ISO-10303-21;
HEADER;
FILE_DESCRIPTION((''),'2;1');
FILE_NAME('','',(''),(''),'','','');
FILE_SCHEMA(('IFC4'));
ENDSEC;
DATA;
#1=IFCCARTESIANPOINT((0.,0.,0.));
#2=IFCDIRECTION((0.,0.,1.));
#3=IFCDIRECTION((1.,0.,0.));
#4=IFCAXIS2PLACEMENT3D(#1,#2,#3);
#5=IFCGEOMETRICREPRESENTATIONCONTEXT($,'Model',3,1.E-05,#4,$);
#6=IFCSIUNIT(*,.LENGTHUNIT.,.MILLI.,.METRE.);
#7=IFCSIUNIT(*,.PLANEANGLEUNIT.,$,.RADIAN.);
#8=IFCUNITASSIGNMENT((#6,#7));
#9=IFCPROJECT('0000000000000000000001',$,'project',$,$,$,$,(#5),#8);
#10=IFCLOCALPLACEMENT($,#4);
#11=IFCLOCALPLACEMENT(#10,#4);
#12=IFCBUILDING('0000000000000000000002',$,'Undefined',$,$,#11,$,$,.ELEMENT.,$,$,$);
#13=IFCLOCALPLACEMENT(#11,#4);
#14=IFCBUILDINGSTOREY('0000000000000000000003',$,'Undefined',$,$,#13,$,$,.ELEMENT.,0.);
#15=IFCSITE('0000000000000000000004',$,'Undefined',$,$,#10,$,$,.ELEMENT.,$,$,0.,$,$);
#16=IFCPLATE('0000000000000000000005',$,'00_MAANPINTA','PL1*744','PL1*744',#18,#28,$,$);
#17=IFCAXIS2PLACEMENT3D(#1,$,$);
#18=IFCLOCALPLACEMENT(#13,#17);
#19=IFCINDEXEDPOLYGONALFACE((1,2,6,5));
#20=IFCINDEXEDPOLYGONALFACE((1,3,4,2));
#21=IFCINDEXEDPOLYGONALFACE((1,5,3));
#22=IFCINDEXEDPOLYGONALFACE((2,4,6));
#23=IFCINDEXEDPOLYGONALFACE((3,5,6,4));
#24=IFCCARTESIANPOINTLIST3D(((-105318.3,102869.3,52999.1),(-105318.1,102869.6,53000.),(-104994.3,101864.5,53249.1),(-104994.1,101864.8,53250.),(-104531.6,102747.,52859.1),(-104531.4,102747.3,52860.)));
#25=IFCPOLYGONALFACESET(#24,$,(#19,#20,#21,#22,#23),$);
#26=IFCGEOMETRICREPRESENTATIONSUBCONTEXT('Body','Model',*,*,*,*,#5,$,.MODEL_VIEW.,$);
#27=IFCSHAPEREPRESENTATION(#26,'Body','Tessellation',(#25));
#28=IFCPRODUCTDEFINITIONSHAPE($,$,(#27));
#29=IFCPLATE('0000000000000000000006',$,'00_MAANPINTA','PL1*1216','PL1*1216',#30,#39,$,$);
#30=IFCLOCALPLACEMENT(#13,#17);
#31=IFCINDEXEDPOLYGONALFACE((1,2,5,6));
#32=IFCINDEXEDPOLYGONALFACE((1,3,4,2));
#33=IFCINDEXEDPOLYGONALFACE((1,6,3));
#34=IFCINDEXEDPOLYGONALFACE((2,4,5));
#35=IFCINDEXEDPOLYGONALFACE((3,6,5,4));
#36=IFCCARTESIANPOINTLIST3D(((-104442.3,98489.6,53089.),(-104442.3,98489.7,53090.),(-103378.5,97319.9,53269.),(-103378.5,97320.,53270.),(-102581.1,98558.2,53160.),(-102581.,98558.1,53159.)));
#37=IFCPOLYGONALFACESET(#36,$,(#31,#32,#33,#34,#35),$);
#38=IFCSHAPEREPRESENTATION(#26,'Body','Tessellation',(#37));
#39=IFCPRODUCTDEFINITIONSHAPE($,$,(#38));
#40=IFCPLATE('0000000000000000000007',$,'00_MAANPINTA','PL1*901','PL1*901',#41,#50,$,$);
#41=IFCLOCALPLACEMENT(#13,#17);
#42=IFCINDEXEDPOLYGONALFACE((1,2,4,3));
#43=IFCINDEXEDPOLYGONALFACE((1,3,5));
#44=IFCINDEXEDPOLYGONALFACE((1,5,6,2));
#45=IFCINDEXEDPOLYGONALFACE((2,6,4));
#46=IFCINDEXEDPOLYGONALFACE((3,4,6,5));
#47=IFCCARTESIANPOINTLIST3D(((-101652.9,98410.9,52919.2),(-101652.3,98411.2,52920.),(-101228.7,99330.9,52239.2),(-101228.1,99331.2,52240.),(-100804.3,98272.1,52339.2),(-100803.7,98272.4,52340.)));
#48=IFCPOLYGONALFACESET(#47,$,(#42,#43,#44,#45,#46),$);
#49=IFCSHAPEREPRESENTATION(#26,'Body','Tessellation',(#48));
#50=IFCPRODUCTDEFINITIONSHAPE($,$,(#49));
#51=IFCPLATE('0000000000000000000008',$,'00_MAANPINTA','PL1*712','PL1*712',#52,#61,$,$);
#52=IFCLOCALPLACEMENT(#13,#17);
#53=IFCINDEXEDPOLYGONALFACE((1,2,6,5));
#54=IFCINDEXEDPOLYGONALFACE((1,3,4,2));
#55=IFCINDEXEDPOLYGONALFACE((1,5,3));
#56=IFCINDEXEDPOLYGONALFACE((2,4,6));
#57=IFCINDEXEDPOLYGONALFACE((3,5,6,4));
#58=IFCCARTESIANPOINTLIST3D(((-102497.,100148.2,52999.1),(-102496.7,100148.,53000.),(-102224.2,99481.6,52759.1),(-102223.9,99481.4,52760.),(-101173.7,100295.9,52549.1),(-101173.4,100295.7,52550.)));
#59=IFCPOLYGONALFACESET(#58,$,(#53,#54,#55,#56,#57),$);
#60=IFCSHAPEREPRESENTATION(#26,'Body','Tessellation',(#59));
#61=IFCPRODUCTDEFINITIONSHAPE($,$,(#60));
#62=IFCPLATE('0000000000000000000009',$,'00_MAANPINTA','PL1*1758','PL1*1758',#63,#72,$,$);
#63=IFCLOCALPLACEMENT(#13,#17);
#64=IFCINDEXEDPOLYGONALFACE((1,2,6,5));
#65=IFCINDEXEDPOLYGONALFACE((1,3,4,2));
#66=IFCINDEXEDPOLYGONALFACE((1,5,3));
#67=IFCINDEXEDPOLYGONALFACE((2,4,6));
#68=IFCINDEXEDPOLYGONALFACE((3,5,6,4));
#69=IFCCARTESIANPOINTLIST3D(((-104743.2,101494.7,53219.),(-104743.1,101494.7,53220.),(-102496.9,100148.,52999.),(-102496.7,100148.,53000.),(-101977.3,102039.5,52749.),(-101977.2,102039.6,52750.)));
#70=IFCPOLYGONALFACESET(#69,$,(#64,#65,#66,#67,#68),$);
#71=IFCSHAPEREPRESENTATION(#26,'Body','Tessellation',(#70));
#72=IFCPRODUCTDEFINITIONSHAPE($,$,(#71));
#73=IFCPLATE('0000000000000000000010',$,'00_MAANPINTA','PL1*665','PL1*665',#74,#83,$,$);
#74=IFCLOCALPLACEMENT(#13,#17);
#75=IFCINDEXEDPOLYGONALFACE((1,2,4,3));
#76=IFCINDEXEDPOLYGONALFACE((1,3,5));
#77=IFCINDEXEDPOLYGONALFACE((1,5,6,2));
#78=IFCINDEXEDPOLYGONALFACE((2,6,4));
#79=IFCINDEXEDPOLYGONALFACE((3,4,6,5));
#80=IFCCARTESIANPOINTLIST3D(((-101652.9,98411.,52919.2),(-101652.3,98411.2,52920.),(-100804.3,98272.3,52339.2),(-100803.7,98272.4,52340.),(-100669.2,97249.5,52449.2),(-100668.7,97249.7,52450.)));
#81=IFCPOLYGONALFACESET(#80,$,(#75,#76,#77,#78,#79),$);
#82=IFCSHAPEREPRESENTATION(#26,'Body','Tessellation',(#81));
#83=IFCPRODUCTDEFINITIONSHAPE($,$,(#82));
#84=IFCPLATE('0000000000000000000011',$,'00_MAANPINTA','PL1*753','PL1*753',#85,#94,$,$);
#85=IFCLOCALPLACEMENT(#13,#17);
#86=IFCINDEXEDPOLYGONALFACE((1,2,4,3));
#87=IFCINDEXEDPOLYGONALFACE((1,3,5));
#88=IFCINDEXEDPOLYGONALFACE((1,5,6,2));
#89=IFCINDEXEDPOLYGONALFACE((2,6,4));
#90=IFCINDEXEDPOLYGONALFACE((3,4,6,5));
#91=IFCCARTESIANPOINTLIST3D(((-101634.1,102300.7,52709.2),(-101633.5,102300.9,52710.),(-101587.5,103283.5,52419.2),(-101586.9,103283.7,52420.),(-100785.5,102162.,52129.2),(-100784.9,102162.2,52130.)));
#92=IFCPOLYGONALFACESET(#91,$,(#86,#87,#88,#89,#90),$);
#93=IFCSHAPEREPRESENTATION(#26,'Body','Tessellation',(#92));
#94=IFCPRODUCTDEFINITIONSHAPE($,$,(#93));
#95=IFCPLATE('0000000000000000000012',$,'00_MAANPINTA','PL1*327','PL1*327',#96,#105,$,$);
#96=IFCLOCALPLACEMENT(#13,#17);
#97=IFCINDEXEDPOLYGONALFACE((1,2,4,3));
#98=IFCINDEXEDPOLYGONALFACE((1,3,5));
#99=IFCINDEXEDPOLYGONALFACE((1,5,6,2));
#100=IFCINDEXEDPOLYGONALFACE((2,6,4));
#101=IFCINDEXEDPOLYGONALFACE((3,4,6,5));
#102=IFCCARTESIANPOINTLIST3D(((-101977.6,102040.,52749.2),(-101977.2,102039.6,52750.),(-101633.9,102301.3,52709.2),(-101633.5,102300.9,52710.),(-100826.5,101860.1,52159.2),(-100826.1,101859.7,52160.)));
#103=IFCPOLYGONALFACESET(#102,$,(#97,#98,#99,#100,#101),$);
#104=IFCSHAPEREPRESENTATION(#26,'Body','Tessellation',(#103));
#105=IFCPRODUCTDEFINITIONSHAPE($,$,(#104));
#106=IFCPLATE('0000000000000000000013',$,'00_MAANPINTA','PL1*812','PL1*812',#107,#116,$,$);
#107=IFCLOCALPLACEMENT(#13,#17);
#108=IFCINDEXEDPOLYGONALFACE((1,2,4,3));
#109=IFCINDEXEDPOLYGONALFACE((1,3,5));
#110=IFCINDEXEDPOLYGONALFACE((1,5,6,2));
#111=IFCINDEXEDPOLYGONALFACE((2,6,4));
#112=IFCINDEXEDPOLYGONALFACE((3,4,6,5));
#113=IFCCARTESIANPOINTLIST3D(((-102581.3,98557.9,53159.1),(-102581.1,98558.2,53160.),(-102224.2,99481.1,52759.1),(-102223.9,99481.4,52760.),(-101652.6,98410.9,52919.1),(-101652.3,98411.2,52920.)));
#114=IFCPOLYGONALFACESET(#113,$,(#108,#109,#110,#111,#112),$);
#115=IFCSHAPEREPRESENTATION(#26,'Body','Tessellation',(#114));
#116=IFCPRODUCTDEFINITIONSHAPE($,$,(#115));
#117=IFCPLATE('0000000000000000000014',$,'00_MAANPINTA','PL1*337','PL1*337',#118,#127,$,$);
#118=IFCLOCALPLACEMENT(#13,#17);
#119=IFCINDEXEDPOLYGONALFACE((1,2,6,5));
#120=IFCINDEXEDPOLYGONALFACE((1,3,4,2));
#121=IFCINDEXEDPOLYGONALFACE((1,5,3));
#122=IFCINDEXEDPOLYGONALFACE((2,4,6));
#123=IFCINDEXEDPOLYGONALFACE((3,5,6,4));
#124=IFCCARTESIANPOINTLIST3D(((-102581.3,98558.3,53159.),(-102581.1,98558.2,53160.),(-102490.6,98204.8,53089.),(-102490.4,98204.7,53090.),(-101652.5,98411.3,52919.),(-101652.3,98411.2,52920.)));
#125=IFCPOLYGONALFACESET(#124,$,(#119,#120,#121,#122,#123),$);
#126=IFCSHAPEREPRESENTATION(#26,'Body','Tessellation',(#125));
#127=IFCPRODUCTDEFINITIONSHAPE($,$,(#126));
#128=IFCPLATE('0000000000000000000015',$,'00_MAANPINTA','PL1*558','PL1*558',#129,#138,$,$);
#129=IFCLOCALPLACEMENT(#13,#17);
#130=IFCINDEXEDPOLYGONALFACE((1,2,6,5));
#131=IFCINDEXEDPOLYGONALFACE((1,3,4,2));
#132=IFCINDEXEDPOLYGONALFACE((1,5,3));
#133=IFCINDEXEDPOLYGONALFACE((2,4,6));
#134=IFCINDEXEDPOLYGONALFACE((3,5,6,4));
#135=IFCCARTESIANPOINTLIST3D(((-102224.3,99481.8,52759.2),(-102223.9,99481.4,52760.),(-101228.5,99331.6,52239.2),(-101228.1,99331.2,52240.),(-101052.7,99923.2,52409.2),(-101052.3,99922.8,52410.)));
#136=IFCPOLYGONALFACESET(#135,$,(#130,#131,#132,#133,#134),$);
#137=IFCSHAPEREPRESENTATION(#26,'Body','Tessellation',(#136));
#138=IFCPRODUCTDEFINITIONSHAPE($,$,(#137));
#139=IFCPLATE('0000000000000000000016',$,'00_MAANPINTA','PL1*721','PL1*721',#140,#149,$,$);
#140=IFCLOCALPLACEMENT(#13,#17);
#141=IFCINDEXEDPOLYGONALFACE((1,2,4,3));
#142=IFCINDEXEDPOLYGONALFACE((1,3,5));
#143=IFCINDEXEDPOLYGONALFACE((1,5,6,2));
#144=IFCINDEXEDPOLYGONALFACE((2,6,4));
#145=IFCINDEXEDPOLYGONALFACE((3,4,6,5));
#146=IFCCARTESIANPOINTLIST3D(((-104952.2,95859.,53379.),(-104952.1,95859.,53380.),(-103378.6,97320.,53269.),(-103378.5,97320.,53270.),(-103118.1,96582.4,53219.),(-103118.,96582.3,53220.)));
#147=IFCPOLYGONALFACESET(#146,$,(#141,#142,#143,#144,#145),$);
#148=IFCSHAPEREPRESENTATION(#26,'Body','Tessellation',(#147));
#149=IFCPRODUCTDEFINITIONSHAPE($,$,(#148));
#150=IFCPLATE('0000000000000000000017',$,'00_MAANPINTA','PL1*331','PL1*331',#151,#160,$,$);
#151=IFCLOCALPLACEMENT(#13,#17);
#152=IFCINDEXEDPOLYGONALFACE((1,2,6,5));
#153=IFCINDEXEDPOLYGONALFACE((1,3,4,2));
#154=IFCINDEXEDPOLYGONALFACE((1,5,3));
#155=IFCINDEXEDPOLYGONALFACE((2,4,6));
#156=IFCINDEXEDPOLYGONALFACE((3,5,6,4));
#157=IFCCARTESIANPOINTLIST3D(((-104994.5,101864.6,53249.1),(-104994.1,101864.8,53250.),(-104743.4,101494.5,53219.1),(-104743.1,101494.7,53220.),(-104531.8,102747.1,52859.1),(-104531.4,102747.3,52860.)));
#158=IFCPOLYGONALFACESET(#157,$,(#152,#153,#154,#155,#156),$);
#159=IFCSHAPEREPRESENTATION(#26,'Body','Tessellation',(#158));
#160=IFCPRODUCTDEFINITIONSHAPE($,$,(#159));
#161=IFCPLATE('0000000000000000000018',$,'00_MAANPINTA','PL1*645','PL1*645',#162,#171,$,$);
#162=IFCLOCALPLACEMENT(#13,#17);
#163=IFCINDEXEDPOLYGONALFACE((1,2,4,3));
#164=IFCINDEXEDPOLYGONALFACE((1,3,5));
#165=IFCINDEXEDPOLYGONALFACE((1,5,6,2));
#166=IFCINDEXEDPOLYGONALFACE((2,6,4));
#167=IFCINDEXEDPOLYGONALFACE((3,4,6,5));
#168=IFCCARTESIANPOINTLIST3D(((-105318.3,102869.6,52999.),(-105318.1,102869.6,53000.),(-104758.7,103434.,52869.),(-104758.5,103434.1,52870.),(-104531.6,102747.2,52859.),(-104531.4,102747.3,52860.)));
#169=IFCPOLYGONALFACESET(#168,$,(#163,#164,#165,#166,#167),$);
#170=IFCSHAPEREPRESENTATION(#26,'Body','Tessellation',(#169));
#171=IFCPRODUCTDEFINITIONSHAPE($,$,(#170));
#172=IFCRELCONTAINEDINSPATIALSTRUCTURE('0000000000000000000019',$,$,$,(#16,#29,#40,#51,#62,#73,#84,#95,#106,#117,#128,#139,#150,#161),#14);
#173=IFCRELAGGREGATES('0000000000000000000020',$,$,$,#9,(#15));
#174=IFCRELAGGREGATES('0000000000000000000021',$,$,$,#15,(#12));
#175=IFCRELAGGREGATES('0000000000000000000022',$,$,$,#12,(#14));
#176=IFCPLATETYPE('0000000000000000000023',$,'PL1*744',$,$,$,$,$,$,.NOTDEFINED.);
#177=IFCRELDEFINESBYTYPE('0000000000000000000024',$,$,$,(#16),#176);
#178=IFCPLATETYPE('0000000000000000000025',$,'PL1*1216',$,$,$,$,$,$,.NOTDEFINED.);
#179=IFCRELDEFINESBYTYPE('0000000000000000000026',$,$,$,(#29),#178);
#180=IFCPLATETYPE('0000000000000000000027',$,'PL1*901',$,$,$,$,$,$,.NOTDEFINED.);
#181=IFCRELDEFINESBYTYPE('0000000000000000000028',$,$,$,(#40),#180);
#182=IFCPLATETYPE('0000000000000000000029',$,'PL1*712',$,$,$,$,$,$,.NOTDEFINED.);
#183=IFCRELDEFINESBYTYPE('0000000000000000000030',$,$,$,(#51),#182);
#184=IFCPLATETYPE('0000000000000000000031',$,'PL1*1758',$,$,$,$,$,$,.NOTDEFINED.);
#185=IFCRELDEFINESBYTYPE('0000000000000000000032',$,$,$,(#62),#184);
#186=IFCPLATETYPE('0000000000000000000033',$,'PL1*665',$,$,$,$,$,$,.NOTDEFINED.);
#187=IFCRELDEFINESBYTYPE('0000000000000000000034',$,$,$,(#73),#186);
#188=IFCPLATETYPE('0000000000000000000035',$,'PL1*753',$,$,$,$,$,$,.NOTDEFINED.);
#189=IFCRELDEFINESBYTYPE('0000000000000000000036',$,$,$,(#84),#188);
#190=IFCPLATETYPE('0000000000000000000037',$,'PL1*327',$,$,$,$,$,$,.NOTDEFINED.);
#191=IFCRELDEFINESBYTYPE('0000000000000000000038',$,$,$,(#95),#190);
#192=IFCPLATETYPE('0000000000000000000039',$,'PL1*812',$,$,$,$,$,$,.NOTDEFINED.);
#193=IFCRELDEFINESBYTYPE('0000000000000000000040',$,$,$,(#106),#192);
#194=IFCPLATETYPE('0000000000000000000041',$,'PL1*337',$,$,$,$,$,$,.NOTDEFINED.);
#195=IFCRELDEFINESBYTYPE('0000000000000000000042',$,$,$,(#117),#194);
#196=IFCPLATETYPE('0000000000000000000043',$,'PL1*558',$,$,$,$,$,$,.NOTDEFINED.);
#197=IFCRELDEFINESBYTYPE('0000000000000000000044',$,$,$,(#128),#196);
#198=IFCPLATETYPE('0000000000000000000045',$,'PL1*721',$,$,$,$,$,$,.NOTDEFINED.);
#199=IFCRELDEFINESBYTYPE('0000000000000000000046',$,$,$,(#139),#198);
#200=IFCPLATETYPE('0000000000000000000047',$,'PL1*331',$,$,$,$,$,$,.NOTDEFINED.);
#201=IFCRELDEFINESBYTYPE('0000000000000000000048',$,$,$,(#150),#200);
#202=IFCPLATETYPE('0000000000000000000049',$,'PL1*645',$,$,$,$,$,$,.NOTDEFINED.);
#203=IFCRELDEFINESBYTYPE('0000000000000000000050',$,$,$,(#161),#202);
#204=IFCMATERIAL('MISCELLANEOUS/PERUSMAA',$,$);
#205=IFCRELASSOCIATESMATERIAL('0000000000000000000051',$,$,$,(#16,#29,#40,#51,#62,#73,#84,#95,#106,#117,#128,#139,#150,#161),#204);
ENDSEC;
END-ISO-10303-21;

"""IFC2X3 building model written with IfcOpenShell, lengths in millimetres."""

from ifc_helpers import new_model, si_unit, frame, origin_with_axes, place, context, subcontext, project, spatial, polyline, outline, extrude, material, type_object, element, save


model = new_model("IFC2X3")

# Units and contexts
model_context = context("Model", 3, precision=1e-05, world=origin_with_axes())
body_context = subcontext(model_context, "Body", "Model", "MODEL_VIEW")
ifc_project = project(units=[si_unit("LENGTHUNIT", "METRE", prefix="MILLI"), si_unit("PLANEANGLEUNIT", "RADIAN")], contexts=[model_context])

# Site, building, storey
site_placement = place(None, origin_with_axes())
site = spatial("IfcSite", under=ifc_project, at=site_placement, Name="Undefined", CompositionType="ELEMENT", RefElevation=0.0)
building_placement = place(site_placement, origin_with_axes())
building = spatial("IfcBuilding", under=site, at=building_placement, Name="Undefined", CompositionType="ELEMENT")
storey_placement = place(building_placement, origin_with_axes())
storey = spatial("IfcBuildingStorey", under=building, at=storey_placement, Name="Undefined", CompositionType="ELEMENT", Elevation=0.0)

# Plates
ifc_material = material(Name="MISCELLANEOUS/PERUSMAA")
plate_type_1 = type_object("IfcPlateType", Name="PL1*744", PredefinedType="NOTDEFINED")
plate_1_placement = place(storey_placement, frame((-104994.2, 101864.7, 53249.5), z_axis=(-0.212169, -0.299815, -0.930105), x_axis=(-0.298591, 0.926146, -0.230427)))
element("IfcPlate", 1, at=plate_1_placement, inside=storey, type_object=plate_type_1, material=ifc_material, Name="00_MAANPINTA", Description="PL1*744", ObjectType="PL1*744", context=body_context, shape_type="SweptSolid", body=[
    extrude(outline(polyline([(0.0, 0.0), (1084.9, 0.0), (769.0, 744.0), (0.0, 0.0)])), frame((0.0, 0.0, -0.5), z_axis=(0.0, 0.0, 1.0), x_axis=(1.0, 0.0, 0.0)), (0.0, 0.0, 1.0), 1.0),
])
plate_type_2 = type_object("IfcPlateType", Name="PL1*1216", PredefinedType="NOTDEFINED")
plate_2_placement = place(storey_placement, frame((-103378.5, 97319.9, 53269.5), z_axis=(0.041553, -0.114937, -0.992503), x_axis=(-0.6685, 0.73506, -0.113111)))
element("IfcPlate", 2, at=plate_2_placement, inside=storey, type_object=plate_type_2, material=ifc_material, Name="00_MAANPINTA", Description="PL1*1216", ObjectType="PL1*1216", context=body_context, shape_type="SweptSolid", body=[
    extrude(outline(polyline([(0.0, 0.0), (1591.4, 0.0), (389.5, 1424.6), (0.0, 0.0)])), frame((0.0, 0.0, -0.5), z_axis=(0.0, 0.0, 1.0), x_axis=(1.0, 0.0, 0.0)), (0.0, 0.0, 1.0), 1.0),
])
plate_type_3 = type_object("IfcPlateType", Name="PL1*901", PredefinedType="NOTDEFINED")
plate_3_placement = place(storey_placement, frame((-101652.6, 98411.0, 52919.6), z_axis=(-0.571172, -0.301041, -0.763634), x_axis=(0.347639, 0.754044, -0.557283)))
element("IfcPlate", 3, at=plate_3_placement, inside=storey, type_object=plate_type_3, material=ifc_material, Name="00_MAANPINTA", Description="PL1*901", ObjectType="PL1*901", context=body_context, shape_type="SweptSolid", body=[
    extrude(outline(polyline([(0.0, 0.0), (1220.2, 0.0), (513.6, 901.1), (0.0, 0.0)])), frame((0.0, 0.0, -0.5), z_axis=(0.0, 0.0, 1.0), x_axis=(1.0, 0.0, 0.0)), (0.0, 0.0, 1.0), 1.0),
])
plate_type_4 = type_object("IfcPlateType", Name="PL1*712", PredefinedType="NOTDEFINED")
plate_4_placement = place(storey_placement, frame((-102224.0, 99481.5, 52759.5), z_axis=(-0.3352, 0.194689, -0.921812), x_axis=(-0.359367, 0.878023, 0.316118)))
element("IfcPlate", 4, at=plate_4_placement, inside=storey, type_object=plate_type_4, material=ifc_material, Name="00_MAANPINTA", Description="PL1*712", ObjectType="PL1*712", context=body_context, shape_type="SweptSolid", body=[
    extrude(outline(polyline([(0.0, 0.0), (759.2, 0.0), (271.1, 1318.0), (0.0, 0.0)])), frame((0.0, 0.0, -0.5), z_axis=(0.0, 0.0, 1.0), x_axis=(1.0, 0.0, 0.0)), (0.0, 0.0, 1.0), 1.0),
])
plate_type_5 = type_object("IfcPlateType", Name="PL1*1758", PredefinedType="NOTDEFINED")
plate_5_placement = place(storey_placement, frame((-102496.8, 100148.0, 52999.5), z_axis=(-0.149796, -0.089002, -0.984703), x_axis=(-0.85467, 0.512379, 0.083703)))
element("IfcPlate", 5, at=plate_5_placement, inside=storey, type_object=plate_type_5, material=ifc_material, Name="00_MAANPINTA", Description="PL1*1758", ObjectType="PL1*1758", context=body_context, shape_type="SweptSolid", body=[
    extrude(outline(polyline([(0.0, 0.0), (2628.3, 0.0), (504.3, 1912.1), (0.0, 0.0)])), frame((0.0, 0.0, -0.5), z_axis=(0.0, 0.0, 1.0), x_axis=(1.0, 0.0, 0.0)), (0.0, 0.0, 1.0), 1.0),
])
plate_type_6 = type_object("IfcPlateType", Name="PL1*665", PredefinedType="NOTDEFINED")
plate_6_placement = place(storey_placement, frame((-101652.6, 98411.1, 52919.6), z_axis=(-0.574756, -0.162175, -0.802094), x_axis=(0.818156, -0.133767, -0.55922)))
element("IfcPlate", 6, at=plate_6_placement, inside=storey, type_object=plate_type_6, material=ifc_material, Name="00_MAANPINTA", Description="PL1*665", ObjectType="PL1*665", context=body_context, shape_type="SweptSolid", body=[
    extrude(outline(polyline([(0.0, 0.0), (1037.2, 0.0), (1223.0, 1020.7), (0.0, 0.0)])), frame((0.0, 0.0, -0.5), z_axis=(0.0, 0.0, 1.0), x_axis=(1.0, 0.0, 0.0)), (0.0, 0.0, 1.0), 1.0),
])
plate_type_7 = type_object("IfcPlateType", Name="PL1*753", PredefinedType="NOTDEFINED")
plate_7_placement = place(storey_placement, frame((-101633.8, 102300.8, 52709.6), z_axis=(-0.574917, -0.206373, -0.791758), x_axis=(0.045436, 0.958123, -0.282728)))
element("IfcPlate", 7, at=plate_7_placement, inside=storey, type_object=plate_type_7, material=ifc_material, Name="00_MAANPINTA", Description="PL1*753", ObjectType="PL1*753", context=body_context, shape_type="SweptSolid", body=[
    extrude(outline(polyline([(0.0, 0.0), (1025.7, 0.0), (69.6, 1034.8), (0.0, 0.0)])), frame((0.0, 0.0, -0.5), z_axis=(0.0, 0.0, 1.0), x_axis=(1.0, 0.0, 0.0)), (0.0, 0.0, 1.0), 1.0),
])
plate_type_8 = type_object("IfcPlateType", Name="PL1*327", PredefinedType="NOTDEFINED")
plate_8_placement = place(storey_placement, frame((-101977.4, 102039.8, 52749.6), z_axis=(-0.378139, 0.367324, -0.849755), x_axis=(0.792686, 0.602609, -0.092253)))
element("IfcPlate", 8, at=plate_8_placement, inside=storey, type_object=plate_type_8, material=ifc_material, Name="00_MAANPINTA", Description="PL1*327", ObjectType="PL1*327", context=body_context, shape_type="SweptSolid", body=[
    extrude(outline(polyline([(0.0, 0.0), (433.6, 0.0), (858.4, 984.1), (0.0, 0.0)])), frame((0.0, 0.0, -0.5), z_axis=(0.0, 0.0, 1.0), x_axis=(1.0, 0.0, 0.0)), (0.0, 0.0, 1.0), 1.0),
])
plate_type_9 = type_object("IfcPlateType", Name="PL1*812", PredefinedType="NOTDEFINED")
plate_9_placement = place(storey_placement, frame((-101652.4, 98411.0, 52919.5), z_axis=(-0.282033, -0.287451, -0.91533), x_axis=(-0.957022, 0.151493, 0.247304)))
element("IfcPlate", 9, at=plate_9_placement, inside=storey, type_object=plate_type_9, material=ifc_material, Name="00_MAANPINTA", Description="PL1*812", ObjectType="PL1*812", context=body_context, shape_type="SweptSolid", body=[
    extrude(outline(polyline([(0.0, 0.0), (970.5, 0.0), (669.6, 1024.4), (0.0, 0.0)])), frame((0.0, 0.0, -0.5), z_axis=(0.0, 0.0, 1.0), x_axis=(1.0, 0.0, 0.0)), (0.0, 0.0, 1.0), 1.0),
])
plate_type_10 = type_object("IfcPlateType", Name="PL1*337", PredefinedType="NOTDEFINED")
plate_10_placement = place(storey_placement, frame((-102490.5, 98204.7, 53089.5), z_axis=(-0.228286, 0.132427, -0.964546), x_axis=(-0.244034, 0.951297, 0.188365)))
element("IfcPlate", 10, at=plate_10_placement, inside=storey, type_object=plate_type_10, material=ifc_material, Name="00_MAANPINTA", Description="PL1*337", ObjectType="PL1*337", context=body_context, shape_type="SweptSolid", body=[
    extrude(outline(polyline([(0.0, 0.0), (371.6, 0.0), (-40.1, 878.8), (0.0, 0.0)])), frame((0.0, 0.0, -0.5), z_axis=(0.0, 0.0, 1.0), x_axis=(1.0, 0.0, 0.0)), (0.0, 0.0, 1.0), 1.0),
])
plate_type_11 = type_object("IfcPlateType", Name="PL1*558", PredefinedType="NOTDEFINED")
plate_11_placement = place(storey_placement, frame((-102224.1, 99481.6, 52759.6), z_axis=(-0.388823, 0.359322, -0.848354), x_axis=(0.901229, 0.339554, -0.269239)))
element("IfcPlate", 11, at=plate_11_placement, inside=storey, type_object=plate_type_11, material=ifc_material, Name="00_MAANPINTA", Description="PL1*558", ObjectType="PL1*558", context=body_context, shape_type="SweptSolid", body=[
    extrude(outline(polyline([(0.0, 0.0), (1300.0, 0.0), (986.4, 558.1), (0.0, 0.0)])), frame((0.0, 0.0, -0.5), z_axis=(0.0, 0.0, 1.0), x_axis=(1.0, 0.0, 0.0)), (0.0, 0.0, 1.0), 1.0),
])
plate_type_12 = type_object("IfcPlateType", Name="PL1*721", PredefinedType="NOTDEFINED")
plate_12_placement = place(storey_placement, frame((-103378.6, 97320.0, 53269.5), z_axis=(-0.099486, 0.032276, -0.994515), x_axis=(0.332327, -0.941005, -0.063784)))
element("IfcPlate", 12, at=plate_12_placement, inside=storey, type_object=plate_type_12, material=ifc_material, Name="00_MAANPINTA", Description="PL1*721", ObjectType="PL1*721", context=body_context, shape_type="SweptSolid", body=[
    extrude(outline(polyline([(0.0, 0.0), (783.9, 0.0), (844.9, 1977.2), (0.0, 0.0)])), frame((0.0, 0.0, -0.5), z_axis=(0.0, 0.0, 1.0), x_axis=(1.0, 0.0, 0.0)), (0.0, 0.0, 1.0), 1.0),
])
plate_type_13 = type_object("IfcPlateType", Name="PL1*331", PredefinedType="NOTDEFINED")
plate_13_placement = place(storey_placement, frame((-104743.3, 101494.6, 53219.6), z_axis=(-0.391308, -0.192533, -0.899894), x_axis=(-0.560172, 0.825668, 0.066932)))
element("IfcPlate", 13, at=plate_13_placement, inside=storey, type_object=plate_type_13, material=ifc_material, Name="00_MAANPINTA", Description="PL1*331", ObjectType="PL1*331", context=body_context, shape_type="SweptSolid", body=[
    extrude(outline(polyline([(0.0, 0.0), (448.2, 0.0), (891.5, 973.8), (0.0, 0.0)])), frame((0.0, 0.0, -0.5), z_axis=(0.0, 0.0, 1.0), x_axis=(1.0, 0.0, 0.0)), (0.0, 0.0, 1.0), 1.0),
])
plate_type_14 = type_object("IfcPlateType", Name="PL1*645", PredefinedType="NOTDEFINED")
plate_14_placement = place(storey_placement, frame((-104531.5, 102747.2, 52859.5), z_axis=(-0.181942, -0.04586, -0.982239), x_axis=(-0.973183, 0.151387, 0.173196)))
element("IfcPlate", 14, at=plate_14_placement, inside=storey, type_object=plate_type_14, material=ifc_material, Name="00_MAANPINTA", Description="PL1*645", ObjectType="PL1*645", context=body_context, shape_type="SweptSolid", body=[
    extrude(outline(polyline([(0.0, 0.0), (808.3, 0.0), (326.7, 645.5), (0.0, 0.0)])), frame((0.0, 0.0, -0.5), z_axis=(0.0, 0.0, 1.0), x_axis=(1.0, 0.0, 0.0)), (0.0, 0.0, 1.0), 1.0),
])

save(model, "model.ifc")
